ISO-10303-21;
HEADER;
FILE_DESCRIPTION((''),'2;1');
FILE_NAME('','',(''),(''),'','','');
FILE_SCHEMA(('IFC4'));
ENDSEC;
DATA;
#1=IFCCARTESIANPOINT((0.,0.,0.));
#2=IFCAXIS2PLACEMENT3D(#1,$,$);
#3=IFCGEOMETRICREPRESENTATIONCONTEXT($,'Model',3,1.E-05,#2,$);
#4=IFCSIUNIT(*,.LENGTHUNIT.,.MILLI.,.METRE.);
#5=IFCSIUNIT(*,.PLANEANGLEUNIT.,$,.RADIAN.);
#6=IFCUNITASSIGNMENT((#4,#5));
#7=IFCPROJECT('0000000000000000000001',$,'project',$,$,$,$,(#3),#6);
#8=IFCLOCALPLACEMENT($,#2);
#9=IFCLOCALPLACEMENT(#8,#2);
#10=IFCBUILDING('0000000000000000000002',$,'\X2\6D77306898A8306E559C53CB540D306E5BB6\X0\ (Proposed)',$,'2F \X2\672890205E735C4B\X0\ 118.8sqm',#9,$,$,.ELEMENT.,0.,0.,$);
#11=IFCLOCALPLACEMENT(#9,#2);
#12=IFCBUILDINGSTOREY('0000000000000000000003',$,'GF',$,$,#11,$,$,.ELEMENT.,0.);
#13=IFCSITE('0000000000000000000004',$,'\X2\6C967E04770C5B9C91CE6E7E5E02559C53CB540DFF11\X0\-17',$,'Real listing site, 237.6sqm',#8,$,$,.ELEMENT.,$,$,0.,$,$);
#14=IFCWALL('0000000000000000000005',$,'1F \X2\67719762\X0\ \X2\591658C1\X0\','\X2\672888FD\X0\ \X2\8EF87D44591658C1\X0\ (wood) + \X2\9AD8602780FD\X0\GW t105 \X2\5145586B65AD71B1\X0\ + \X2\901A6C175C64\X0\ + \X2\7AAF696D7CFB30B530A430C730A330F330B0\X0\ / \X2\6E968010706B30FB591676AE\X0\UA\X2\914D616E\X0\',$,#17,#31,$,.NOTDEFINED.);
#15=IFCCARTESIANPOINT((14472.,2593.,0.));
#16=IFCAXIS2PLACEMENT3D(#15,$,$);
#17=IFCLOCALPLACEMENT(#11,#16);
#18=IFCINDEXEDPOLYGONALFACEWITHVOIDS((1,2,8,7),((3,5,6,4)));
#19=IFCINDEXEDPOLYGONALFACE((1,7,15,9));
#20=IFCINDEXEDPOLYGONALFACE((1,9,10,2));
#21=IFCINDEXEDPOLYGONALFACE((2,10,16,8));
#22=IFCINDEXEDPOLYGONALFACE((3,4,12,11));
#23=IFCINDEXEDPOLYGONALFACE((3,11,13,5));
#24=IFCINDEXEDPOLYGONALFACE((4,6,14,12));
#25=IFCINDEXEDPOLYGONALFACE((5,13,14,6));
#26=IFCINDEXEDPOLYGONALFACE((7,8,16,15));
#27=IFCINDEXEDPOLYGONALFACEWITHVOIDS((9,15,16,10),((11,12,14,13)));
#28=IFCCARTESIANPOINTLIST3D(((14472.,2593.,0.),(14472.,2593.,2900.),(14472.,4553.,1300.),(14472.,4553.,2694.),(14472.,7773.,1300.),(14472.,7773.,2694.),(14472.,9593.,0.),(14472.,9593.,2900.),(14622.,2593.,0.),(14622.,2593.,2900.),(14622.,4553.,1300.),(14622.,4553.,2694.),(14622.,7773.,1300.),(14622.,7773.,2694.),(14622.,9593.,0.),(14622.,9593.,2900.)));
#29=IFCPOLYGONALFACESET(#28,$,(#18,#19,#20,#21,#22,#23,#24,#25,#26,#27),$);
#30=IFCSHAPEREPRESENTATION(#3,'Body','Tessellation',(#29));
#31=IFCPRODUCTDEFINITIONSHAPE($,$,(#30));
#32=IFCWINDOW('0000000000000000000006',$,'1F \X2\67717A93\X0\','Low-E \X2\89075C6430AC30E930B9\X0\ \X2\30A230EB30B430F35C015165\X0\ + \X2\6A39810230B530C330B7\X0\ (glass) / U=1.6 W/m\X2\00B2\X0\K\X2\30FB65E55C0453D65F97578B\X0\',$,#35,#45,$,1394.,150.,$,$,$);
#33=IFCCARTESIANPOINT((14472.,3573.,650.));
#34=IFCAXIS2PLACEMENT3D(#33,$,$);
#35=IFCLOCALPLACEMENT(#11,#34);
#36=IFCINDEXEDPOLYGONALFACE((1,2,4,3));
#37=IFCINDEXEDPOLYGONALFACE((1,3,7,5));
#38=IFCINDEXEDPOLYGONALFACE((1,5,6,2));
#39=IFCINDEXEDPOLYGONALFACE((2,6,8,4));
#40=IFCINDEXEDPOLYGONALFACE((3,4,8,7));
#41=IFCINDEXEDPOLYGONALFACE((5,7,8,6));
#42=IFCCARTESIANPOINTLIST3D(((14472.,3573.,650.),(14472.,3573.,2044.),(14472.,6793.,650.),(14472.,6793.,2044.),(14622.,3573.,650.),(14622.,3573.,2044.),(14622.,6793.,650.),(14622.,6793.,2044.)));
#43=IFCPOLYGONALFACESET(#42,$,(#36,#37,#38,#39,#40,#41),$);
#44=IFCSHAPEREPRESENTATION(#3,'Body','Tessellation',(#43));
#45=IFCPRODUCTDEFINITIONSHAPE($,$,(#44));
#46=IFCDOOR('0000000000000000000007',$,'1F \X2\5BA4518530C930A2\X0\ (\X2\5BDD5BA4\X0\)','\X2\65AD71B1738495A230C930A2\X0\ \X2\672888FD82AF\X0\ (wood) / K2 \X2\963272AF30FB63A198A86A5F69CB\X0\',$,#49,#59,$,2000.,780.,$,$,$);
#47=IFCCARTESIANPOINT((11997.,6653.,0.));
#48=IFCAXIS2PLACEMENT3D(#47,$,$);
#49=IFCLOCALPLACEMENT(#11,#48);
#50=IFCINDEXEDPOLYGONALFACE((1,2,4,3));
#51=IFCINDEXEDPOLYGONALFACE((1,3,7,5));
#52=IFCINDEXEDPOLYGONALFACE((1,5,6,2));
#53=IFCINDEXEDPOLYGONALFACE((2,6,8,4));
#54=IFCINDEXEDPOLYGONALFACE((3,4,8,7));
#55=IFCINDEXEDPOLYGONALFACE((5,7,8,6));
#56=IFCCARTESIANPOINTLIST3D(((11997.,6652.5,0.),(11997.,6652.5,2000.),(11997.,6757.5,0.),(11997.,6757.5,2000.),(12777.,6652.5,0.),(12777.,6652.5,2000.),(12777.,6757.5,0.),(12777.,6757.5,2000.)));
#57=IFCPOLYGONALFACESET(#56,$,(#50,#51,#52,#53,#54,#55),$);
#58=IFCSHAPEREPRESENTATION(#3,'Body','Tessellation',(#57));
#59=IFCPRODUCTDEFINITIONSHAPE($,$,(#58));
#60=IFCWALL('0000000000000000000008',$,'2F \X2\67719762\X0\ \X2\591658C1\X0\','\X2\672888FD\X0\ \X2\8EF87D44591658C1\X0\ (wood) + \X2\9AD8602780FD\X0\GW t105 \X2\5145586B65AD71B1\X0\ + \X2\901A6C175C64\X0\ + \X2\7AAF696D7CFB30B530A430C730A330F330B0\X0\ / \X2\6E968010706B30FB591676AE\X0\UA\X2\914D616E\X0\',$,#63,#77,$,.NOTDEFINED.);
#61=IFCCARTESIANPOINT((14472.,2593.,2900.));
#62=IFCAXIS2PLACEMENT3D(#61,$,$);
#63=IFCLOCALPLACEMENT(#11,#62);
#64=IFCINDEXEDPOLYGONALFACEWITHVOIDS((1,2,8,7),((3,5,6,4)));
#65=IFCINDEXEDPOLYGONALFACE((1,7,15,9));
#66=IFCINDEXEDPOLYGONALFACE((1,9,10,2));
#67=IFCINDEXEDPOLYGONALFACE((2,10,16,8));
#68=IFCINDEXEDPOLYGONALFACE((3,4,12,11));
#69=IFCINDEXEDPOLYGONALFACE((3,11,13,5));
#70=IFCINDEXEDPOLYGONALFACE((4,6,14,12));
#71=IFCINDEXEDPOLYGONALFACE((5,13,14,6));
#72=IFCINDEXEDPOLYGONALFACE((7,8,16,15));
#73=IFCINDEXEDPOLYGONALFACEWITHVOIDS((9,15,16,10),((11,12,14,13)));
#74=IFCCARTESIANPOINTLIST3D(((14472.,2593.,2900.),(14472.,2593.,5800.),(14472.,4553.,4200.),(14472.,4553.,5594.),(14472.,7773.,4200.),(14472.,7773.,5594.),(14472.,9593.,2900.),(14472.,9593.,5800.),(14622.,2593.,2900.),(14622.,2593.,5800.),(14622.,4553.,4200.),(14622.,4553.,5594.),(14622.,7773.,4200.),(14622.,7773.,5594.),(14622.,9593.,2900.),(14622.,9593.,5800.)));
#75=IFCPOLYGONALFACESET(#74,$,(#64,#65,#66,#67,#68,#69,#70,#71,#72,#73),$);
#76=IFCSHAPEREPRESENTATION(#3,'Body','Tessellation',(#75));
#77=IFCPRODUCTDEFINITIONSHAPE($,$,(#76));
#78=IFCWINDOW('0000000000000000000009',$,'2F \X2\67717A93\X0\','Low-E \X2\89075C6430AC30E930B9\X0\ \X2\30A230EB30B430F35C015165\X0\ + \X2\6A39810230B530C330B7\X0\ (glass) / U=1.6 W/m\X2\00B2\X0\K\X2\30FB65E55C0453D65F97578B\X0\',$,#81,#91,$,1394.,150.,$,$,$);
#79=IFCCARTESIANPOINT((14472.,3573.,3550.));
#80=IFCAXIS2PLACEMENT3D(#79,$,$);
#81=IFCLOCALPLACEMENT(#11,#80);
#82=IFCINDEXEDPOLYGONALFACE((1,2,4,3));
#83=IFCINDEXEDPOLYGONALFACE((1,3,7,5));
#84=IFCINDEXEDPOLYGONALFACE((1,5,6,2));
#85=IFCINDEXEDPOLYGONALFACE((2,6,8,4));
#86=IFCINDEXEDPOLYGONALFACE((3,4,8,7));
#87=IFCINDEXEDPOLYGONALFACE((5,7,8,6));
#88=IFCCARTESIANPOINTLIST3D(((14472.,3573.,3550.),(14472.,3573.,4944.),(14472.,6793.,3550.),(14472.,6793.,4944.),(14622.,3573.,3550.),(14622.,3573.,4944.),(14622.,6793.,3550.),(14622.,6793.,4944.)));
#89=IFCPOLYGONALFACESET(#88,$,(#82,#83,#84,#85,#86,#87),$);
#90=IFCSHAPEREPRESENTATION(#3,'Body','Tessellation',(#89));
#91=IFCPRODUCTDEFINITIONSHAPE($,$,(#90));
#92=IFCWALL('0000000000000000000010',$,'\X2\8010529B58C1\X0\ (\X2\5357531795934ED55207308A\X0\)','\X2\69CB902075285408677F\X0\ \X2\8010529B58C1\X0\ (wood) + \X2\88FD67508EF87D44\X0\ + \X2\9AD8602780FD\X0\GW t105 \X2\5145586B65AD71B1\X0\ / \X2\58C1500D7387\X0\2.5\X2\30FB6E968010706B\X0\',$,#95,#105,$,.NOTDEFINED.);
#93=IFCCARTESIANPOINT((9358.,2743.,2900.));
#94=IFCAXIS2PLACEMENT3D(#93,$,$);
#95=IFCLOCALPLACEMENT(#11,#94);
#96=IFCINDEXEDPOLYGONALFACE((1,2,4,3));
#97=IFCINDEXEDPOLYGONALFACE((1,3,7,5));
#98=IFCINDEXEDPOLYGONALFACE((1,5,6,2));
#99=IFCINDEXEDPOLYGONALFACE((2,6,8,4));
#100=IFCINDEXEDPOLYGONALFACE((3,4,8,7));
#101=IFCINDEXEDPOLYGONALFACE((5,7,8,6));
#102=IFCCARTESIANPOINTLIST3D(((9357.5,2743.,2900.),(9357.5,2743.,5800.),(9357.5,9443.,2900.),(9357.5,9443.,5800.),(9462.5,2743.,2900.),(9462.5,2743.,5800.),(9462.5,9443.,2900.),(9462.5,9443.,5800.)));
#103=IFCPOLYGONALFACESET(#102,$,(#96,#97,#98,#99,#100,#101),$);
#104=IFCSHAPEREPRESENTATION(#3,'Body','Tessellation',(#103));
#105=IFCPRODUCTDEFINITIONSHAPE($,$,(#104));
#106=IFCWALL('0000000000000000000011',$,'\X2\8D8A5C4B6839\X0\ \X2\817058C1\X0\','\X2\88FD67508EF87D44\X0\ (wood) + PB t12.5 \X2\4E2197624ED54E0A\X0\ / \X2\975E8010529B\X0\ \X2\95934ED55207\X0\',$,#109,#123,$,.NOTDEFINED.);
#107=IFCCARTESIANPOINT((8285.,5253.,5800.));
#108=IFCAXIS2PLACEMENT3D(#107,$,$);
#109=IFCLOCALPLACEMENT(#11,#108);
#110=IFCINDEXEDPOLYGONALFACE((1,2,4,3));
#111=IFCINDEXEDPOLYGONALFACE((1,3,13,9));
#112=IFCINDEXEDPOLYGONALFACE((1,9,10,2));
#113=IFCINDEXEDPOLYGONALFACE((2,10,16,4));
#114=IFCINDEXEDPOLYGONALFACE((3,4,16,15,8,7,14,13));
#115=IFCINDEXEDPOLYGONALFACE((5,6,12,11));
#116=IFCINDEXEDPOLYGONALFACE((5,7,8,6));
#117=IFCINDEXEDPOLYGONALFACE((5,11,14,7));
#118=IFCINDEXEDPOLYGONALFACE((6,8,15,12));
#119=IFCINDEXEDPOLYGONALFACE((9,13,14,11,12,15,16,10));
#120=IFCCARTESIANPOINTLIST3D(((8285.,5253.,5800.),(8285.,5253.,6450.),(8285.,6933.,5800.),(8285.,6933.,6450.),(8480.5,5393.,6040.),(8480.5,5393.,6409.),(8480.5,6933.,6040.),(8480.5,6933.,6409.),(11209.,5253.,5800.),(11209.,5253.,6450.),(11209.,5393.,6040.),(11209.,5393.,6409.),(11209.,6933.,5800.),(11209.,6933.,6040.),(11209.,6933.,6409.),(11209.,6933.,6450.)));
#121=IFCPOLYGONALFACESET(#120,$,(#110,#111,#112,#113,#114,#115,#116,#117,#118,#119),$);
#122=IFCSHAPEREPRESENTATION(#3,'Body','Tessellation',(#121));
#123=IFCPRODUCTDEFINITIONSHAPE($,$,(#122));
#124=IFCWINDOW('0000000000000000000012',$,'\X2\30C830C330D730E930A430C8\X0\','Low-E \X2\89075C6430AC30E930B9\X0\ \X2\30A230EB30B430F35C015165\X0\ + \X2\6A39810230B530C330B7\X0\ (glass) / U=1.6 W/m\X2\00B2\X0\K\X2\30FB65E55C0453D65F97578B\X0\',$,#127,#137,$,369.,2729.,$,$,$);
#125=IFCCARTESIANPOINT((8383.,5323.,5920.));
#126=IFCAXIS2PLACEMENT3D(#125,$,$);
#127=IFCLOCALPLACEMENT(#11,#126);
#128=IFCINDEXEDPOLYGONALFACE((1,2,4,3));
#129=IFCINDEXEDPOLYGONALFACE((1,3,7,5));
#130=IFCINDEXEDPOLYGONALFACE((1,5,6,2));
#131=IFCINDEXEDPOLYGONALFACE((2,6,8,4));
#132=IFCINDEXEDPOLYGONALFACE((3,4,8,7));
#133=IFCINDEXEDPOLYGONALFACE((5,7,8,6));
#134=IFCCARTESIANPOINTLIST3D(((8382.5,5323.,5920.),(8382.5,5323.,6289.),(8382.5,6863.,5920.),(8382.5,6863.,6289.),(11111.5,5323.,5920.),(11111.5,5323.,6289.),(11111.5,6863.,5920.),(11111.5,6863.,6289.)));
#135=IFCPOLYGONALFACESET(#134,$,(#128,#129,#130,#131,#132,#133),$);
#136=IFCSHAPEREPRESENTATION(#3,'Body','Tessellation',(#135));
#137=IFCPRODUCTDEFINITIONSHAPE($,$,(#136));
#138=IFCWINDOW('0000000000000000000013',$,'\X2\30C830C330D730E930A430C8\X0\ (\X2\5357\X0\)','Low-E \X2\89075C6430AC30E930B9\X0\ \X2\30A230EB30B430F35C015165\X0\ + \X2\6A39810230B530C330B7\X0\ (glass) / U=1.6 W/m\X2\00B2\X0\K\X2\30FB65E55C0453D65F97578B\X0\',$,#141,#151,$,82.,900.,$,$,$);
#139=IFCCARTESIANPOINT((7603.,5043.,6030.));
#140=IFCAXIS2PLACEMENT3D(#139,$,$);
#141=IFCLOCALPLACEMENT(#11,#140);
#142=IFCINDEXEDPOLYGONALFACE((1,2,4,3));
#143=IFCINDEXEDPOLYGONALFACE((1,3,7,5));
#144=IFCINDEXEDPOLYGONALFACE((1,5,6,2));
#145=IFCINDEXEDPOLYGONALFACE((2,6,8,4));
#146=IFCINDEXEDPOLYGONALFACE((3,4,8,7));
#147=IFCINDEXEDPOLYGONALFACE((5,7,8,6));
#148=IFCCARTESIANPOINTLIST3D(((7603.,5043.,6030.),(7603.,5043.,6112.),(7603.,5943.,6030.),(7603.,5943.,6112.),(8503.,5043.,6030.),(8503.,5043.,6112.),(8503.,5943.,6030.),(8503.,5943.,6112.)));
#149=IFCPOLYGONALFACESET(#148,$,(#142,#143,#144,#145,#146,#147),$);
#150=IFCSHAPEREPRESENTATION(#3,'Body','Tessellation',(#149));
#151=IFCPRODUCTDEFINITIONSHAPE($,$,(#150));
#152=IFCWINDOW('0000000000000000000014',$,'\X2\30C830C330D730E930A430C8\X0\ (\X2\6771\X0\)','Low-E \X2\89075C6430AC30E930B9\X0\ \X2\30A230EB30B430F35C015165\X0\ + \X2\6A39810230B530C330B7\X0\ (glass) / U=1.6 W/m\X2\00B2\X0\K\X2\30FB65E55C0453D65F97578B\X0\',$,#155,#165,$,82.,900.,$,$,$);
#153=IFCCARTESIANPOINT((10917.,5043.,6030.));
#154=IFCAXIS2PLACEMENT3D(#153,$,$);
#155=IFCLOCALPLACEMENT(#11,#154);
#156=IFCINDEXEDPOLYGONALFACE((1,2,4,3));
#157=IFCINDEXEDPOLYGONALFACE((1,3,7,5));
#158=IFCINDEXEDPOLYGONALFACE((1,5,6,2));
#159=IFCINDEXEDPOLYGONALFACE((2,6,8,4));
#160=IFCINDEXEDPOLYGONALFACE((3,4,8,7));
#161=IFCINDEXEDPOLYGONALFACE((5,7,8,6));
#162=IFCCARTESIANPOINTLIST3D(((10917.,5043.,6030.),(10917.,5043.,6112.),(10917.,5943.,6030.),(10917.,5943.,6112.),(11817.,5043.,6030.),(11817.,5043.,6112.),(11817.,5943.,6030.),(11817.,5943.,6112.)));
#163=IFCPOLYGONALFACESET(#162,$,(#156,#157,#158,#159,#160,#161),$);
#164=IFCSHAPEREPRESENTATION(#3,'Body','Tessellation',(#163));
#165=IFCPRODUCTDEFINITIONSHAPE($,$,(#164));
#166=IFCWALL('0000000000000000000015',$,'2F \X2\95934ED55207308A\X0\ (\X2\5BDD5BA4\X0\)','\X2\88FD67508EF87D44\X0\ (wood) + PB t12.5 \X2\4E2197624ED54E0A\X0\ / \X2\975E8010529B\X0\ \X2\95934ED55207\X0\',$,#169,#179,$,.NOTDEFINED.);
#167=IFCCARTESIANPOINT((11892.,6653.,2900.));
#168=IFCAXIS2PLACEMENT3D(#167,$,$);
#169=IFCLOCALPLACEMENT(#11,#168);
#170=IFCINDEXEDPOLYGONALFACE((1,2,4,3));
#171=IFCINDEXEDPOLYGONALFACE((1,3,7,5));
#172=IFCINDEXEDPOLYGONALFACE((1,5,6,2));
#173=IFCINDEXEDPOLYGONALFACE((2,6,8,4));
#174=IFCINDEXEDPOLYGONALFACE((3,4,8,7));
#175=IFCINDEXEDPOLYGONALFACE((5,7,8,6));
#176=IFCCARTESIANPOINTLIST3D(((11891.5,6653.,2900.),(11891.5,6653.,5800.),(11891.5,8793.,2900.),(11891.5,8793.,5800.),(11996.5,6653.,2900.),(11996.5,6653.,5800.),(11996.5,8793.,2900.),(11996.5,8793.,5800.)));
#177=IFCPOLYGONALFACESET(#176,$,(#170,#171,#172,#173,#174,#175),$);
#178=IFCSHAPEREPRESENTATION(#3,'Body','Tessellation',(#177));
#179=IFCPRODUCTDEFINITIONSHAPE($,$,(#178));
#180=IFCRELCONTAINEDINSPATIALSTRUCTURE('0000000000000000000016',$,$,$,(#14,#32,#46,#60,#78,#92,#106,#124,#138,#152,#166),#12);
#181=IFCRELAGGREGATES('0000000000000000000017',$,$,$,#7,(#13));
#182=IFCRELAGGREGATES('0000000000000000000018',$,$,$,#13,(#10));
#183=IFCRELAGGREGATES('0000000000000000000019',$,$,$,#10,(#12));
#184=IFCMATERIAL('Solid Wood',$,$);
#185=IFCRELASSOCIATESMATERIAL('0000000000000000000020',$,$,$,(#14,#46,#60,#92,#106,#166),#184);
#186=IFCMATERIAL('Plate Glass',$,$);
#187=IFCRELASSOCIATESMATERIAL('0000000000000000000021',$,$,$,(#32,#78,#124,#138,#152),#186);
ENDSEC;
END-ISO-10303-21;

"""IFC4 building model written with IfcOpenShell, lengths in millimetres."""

from ifc_helpers import new_model, si_unit, frame, frame_2d, origin, place, context, project, spatial, rectangle, extrude, material, element, fill, save


model = new_model("IFC4")

# Units and contexts
model_context = context("Model", 3, precision=1e-05, world=origin())
ifc_project = project(units=[si_unit("LENGTHUNIT", "METRE", prefix="MILLI"), si_unit("PLANEANGLEUNIT", "RADIAN")], contexts=[model_context])

# Site, building, storey
site_placement = place(None, origin())
site = spatial("IfcSite", under=ifc_project, at=site_placement, Name="沖縄県宜野湾市喜友名１-17", ObjectType="Real listing site, 237.6sqm", CompositionType="ELEMENT", RefElevation=0.0)
building_placement = place(site_placement, origin())
building = spatial("IfcBuilding", under=site, at=building_placement, Name="海と風の喜友名の家 (Proposed)", ObjectType="2F 木造平屋 118.8sqm", CompositionType="ELEMENT", ElevationOfRefHeight=0.0, ElevationOfTerrain=0.0)
storey_placement = place(building_placement, origin())
storey = spatial("IfcBuildingStorey", under=building, at=storey_placement, Name="GF", CompositionType="ELEMENT", Elevation=0.0)

# Wall, opening, window
ifc_material_1 = material(Name="Solid Wood")
wall_1_placement = place(storey_placement, frame((14472.0, 2593.0, 0.0)))
wall_1 = element("IfcWall", 1, at=wall_1_placement, inside=storey, material=ifc_material_1, Name="1F 東面 外壁", Description="木製 軸組外壁 (wood) + 高性能GW t105 充填断熱 + 通気層 + 窯業系サイディング / 準耐火・外皮UA配慮", PredefinedType="NOTDEFINED", context=model_context, shape_type="SweptSolid", body=[
    extrude(rectangle(XDim=150.0, YDim=7000.0, at=frame_2d((75.0, 3500.0))), frame((14472.0, 2593.0, 0.0)), (0.0, 0.0, 1.0), 2900.0),
])
opening_1_placement = place(storey_placement, frame((14472.0, 3573.0, 650.0)))
opening_1 = element("IfcOpeningElement", 2, at=opening_1_placement, cuts=wall_1, PredefinedType="NOTDEFINED", context=model_context, shape_type="SweptSolid", body=[
    extrude(rectangle(XDim=150.0, YDim=3220.0, at=frame_2d((75.0, 1610.0))), frame((14472.0, 3573.0, 650.0)), (0.0, 0.0, 1.0), 1394.0),
])
ifc_material_2 = material(Name="Plate Glass")
window_1_placement = place(storey_placement, frame((14472.0, 3573.0, 650.0)))
window_1 = element("IfcWindow", 3, at=window_1_placement, inside=storey, material=ifc_material_2, Name="1F 東窓", Description="Low-E 複層ガラス アルゴン封入 + 樹脂サッシ (glass) / U=1.6 W/m²K・日射取得型", OverallHeight=1394.0, OverallWidth=150.0, context=model_context, shape_type="SweptSolid", body=[
    extrude(rectangle(XDim=150.0, YDim=3220.0, at=frame_2d((75.0, 1610.0))), frame((14472.0, 3573.0, 650.0)), (0.0, 0.0, 1.0), 1394.0),
])
fill(opening_1, window_1)

# Door
door_1_placement = place(storey_placement, frame((11997.0, 6653.0, 0.0)))
element("IfcDoor", 4, at=door_1_placement, inside=storey, material=ifc_material_1, Name="1F 室内ドア (寝室)", Description="断熱玄関ドア 木製芯 (wood) / K2 防犯・採風機構", OverallHeight=2000.0, OverallWidth=780.0, context=model_context, shape_type="SweptSolid", body=[
    extrude(rectangle(XDim=780.0, YDim=105.0, at=frame_2d((390.0, 52.0))), frame((11997.0, 6653.0, 0.0)), (0.0, 0.0, 1.0), 2000.0),
])

# Wall, opening, window
wall_2_placement = place(storey_placement, frame((14472.0, 2593.0, 2900.0)))
wall_2 = element("IfcWall", 5, at=wall_2_placement, inside=storey, material=ifc_material_1, Name="2F 東面 外壁", Description="木製 軸組外壁 (wood) + 高性能GW t105 充填断熱 + 通気層 + 窯業系サイディング / 準耐火・外皮UA配慮", PredefinedType="NOTDEFINED", context=model_context, shape_type="SweptSolid", body=[
    extrude(rectangle(XDim=150.0, YDim=7000.0, at=frame_2d((75.0, 3500.0))), frame((14472.0, 2593.0, 2900.0)), (0.0, 0.0, 1.0), 2900.0),
])
opening_2_placement = place(storey_placement, frame((14472.0, 3573.0, 3550.0)))
opening_2 = element("IfcOpeningElement", 6, at=opening_2_placement, cuts=wall_2, PredefinedType="NOTDEFINED", context=model_context, shape_type="SweptSolid", body=[
    extrude(rectangle(XDim=150.0, YDim=3220.0, at=frame_2d((75.0, 1610.0))), frame((14472.0, 3573.0, 3550.0)), (0.0, 0.0, 1.0), 1394.0),
])
window_2_placement = place(storey_placement, frame((14472.0, 3573.0, 3550.0)))
window_2 = element("IfcWindow", 7, at=window_2_placement, inside=storey, material=ifc_material_2, Name="2F 東窓", Description="Low-E 複層ガラス アルゴン封入 + 樹脂サッシ (glass) / U=1.6 W/m²K・日射取得型", OverallHeight=1394.0, OverallWidth=150.0, context=model_context, shape_type="SweptSolid", body=[
    extrude(rectangle(XDim=150.0, YDim=3220.0, at=frame_2d((75.0, 1610.0))), frame((14472.0, 3573.0, 3550.0)), (0.0, 0.0, 1.0), 1394.0),
])
fill(opening_2, window_2)

# Wall
wall_3_placement = place(storey_placement, frame((9358.0, 2743.0, 2900.0)))
element("IfcWall", 8, at=wall_3_placement, inside=storey, material=ifc_material_1, Name="耐力壁 (南北間仕切り)", Description="構造用合板 耐力壁 (wood) + 製材軸組 + 高性能GW t105 充填断熱 / 壁倍率2.5・準耐火", PredefinedType="NOTDEFINED", context=model_context, shape_type="SweptSolid", body=[
    extrude(rectangle(XDim=105.0, YDim=6700.0, at=frame_2d((52.0, 3350.0))), frame((9358.0, 2743.0, 2900.0)), (0.0, 0.0, 1.0), 2900.0),
])

# Wall, openings, windows
wall_4_placement = place(storey_placement, frame((8285.0, 5253.0, 5800.0)))
wall_4 = element("IfcWall", 9, at=wall_4_placement, inside=storey, material=ifc_material_1, Name="越屋根 腰壁", Description="製材軸組 (wood) + PB t12.5 両面仕上 / 非耐力 間仕切", PredefinedType="NOTDEFINED", context=model_context, shape_type="SweptSolid", body=[
    extrude(rectangle(XDim=2924.0, YDim=1680.0, at=frame_2d((1462.0, 840.0))), frame((8285.0, 5253.0, 5800.0)), (0.0, 0.0, 1.0), 650.0),
])
opening_3_placement = place(storey_placement, frame((8383.0, 5323.0, 5920.0)))
opening_3 = element("IfcOpeningElement", 10, at=opening_3_placement, cuts=wall_4, PredefinedType="NOTDEFINED", context=model_context, shape_type="SweptSolid", body=[
    extrude(rectangle(XDim=2729.0, YDim=1540.0, at=frame_2d((1364.0, 770.0))), frame((8383.0, 5323.0, 5920.0)), (0.0, 0.0, 1.0), 369.0),
])
opening_4_placement = place(storey_placement, frame((7603.0, 5043.0, 6030.0)))
opening_4 = element("IfcOpeningElement", 11, at=opening_4_placement, cuts=wall_4, PredefinedType="NOTDEFINED", context=model_context, shape_type="SweptSolid", body=[
    extrude(rectangle(XDim=900.0, YDim=900.0, at=frame_2d((450.0, 450.0))), frame((7603.0, 5043.0, 6030.0)), (0.0, 0.0, 1.0), 82.0),
])
opening_5_placement = place(storey_placement, frame((10917.0, 5043.0, 6030.0)))
opening_5 = element("IfcOpeningElement", 12, at=opening_5_placement, cuts=wall_4, PredefinedType="NOTDEFINED", context=model_context, shape_type="SweptSolid", body=[
    extrude(rectangle(XDim=900.0, YDim=900.0, at=frame_2d((450.0, 450.0))), frame((10917.0, 5043.0, 6030.0)), (0.0, 0.0, 1.0), 82.0),
])
window_3_placement = place(storey_placement, frame((8383.0, 5323.0, 5920.0)))
window_3 = element("IfcWindow", 13, at=window_3_placement, inside=storey, material=ifc_material_2, Name="トップライト", Description="Low-E 複層ガラス アルゴン封入 + 樹脂サッシ (glass) / U=1.6 W/m²K・日射取得型", OverallHeight=369.0, OverallWidth=2729.0, context=model_context, shape_type="SweptSolid", body=[
    extrude(rectangle(XDim=2729.0, YDim=1540.0, at=frame_2d((1364.0, 770.0))), frame((8383.0, 5323.0, 5920.0)), (0.0, 0.0, 1.0), 369.0),
])
fill(opening_3, window_3)
window_4_placement = place(storey_placement, frame((7603.0, 5043.0, 6030.0)))
window_4 = element("IfcWindow", 14, at=window_4_placement, inside=storey, material=ifc_material_2, Name="トップライト (南)", Description="Low-E 複層ガラス アルゴン封入 + 樹脂サッシ (glass) / U=1.6 W/m²K・日射取得型", OverallHeight=82.0, OverallWidth=900.0, context=model_context, shape_type="SweptSolid", body=[
    extrude(rectangle(XDim=900.0, YDim=900.0, at=frame_2d((450.0, 450.0))), frame((7603.0, 5043.0, 6030.0)), (0.0, 0.0, 1.0), 82.0),
])
fill(opening_4, window_4)
window_5_placement = place(storey_placement, frame((10917.0, 5043.0, 6030.0)))
window_5 = element("IfcWindow", 15, at=window_5_placement, inside=storey, material=ifc_material_2, Name="トップライト (東)", Description="Low-E 複層ガラス アルゴン封入 + 樹脂サッシ (glass) / U=1.6 W/m²K・日射取得型", OverallHeight=82.0, OverallWidth=900.0, context=model_context, shape_type="SweptSolid", body=[
    extrude(rectangle(XDim=900.0, YDim=900.0, at=frame_2d((450.0, 450.0))), frame((10917.0, 5043.0, 6030.0)), (0.0, 0.0, 1.0), 82.0),
])
fill(opening_5, window_5)

# Wall
wall_5_placement = place(storey_placement, frame((11892.0, 6653.0, 2900.0)))
element("IfcWall", 16, at=wall_5_placement, inside=storey, material=ifc_material_1, Name="2F 間仕切り (寝室)", Description="製材軸組 (wood) + PB t12.5 両面仕上 / 非耐力 間仕切", PredefinedType="NOTDEFINED", context=model_context, shape_type="SweptSolid", body=[
    extrude(rectangle(XDim=105.0, YDim=2140.0, at=frame_2d((52.0, 1070.0))), frame((11892.0, 6653.0, 2900.0)), (0.0, 0.0, 1.0), 2900.0),
])

save(model, "model.ifc")
